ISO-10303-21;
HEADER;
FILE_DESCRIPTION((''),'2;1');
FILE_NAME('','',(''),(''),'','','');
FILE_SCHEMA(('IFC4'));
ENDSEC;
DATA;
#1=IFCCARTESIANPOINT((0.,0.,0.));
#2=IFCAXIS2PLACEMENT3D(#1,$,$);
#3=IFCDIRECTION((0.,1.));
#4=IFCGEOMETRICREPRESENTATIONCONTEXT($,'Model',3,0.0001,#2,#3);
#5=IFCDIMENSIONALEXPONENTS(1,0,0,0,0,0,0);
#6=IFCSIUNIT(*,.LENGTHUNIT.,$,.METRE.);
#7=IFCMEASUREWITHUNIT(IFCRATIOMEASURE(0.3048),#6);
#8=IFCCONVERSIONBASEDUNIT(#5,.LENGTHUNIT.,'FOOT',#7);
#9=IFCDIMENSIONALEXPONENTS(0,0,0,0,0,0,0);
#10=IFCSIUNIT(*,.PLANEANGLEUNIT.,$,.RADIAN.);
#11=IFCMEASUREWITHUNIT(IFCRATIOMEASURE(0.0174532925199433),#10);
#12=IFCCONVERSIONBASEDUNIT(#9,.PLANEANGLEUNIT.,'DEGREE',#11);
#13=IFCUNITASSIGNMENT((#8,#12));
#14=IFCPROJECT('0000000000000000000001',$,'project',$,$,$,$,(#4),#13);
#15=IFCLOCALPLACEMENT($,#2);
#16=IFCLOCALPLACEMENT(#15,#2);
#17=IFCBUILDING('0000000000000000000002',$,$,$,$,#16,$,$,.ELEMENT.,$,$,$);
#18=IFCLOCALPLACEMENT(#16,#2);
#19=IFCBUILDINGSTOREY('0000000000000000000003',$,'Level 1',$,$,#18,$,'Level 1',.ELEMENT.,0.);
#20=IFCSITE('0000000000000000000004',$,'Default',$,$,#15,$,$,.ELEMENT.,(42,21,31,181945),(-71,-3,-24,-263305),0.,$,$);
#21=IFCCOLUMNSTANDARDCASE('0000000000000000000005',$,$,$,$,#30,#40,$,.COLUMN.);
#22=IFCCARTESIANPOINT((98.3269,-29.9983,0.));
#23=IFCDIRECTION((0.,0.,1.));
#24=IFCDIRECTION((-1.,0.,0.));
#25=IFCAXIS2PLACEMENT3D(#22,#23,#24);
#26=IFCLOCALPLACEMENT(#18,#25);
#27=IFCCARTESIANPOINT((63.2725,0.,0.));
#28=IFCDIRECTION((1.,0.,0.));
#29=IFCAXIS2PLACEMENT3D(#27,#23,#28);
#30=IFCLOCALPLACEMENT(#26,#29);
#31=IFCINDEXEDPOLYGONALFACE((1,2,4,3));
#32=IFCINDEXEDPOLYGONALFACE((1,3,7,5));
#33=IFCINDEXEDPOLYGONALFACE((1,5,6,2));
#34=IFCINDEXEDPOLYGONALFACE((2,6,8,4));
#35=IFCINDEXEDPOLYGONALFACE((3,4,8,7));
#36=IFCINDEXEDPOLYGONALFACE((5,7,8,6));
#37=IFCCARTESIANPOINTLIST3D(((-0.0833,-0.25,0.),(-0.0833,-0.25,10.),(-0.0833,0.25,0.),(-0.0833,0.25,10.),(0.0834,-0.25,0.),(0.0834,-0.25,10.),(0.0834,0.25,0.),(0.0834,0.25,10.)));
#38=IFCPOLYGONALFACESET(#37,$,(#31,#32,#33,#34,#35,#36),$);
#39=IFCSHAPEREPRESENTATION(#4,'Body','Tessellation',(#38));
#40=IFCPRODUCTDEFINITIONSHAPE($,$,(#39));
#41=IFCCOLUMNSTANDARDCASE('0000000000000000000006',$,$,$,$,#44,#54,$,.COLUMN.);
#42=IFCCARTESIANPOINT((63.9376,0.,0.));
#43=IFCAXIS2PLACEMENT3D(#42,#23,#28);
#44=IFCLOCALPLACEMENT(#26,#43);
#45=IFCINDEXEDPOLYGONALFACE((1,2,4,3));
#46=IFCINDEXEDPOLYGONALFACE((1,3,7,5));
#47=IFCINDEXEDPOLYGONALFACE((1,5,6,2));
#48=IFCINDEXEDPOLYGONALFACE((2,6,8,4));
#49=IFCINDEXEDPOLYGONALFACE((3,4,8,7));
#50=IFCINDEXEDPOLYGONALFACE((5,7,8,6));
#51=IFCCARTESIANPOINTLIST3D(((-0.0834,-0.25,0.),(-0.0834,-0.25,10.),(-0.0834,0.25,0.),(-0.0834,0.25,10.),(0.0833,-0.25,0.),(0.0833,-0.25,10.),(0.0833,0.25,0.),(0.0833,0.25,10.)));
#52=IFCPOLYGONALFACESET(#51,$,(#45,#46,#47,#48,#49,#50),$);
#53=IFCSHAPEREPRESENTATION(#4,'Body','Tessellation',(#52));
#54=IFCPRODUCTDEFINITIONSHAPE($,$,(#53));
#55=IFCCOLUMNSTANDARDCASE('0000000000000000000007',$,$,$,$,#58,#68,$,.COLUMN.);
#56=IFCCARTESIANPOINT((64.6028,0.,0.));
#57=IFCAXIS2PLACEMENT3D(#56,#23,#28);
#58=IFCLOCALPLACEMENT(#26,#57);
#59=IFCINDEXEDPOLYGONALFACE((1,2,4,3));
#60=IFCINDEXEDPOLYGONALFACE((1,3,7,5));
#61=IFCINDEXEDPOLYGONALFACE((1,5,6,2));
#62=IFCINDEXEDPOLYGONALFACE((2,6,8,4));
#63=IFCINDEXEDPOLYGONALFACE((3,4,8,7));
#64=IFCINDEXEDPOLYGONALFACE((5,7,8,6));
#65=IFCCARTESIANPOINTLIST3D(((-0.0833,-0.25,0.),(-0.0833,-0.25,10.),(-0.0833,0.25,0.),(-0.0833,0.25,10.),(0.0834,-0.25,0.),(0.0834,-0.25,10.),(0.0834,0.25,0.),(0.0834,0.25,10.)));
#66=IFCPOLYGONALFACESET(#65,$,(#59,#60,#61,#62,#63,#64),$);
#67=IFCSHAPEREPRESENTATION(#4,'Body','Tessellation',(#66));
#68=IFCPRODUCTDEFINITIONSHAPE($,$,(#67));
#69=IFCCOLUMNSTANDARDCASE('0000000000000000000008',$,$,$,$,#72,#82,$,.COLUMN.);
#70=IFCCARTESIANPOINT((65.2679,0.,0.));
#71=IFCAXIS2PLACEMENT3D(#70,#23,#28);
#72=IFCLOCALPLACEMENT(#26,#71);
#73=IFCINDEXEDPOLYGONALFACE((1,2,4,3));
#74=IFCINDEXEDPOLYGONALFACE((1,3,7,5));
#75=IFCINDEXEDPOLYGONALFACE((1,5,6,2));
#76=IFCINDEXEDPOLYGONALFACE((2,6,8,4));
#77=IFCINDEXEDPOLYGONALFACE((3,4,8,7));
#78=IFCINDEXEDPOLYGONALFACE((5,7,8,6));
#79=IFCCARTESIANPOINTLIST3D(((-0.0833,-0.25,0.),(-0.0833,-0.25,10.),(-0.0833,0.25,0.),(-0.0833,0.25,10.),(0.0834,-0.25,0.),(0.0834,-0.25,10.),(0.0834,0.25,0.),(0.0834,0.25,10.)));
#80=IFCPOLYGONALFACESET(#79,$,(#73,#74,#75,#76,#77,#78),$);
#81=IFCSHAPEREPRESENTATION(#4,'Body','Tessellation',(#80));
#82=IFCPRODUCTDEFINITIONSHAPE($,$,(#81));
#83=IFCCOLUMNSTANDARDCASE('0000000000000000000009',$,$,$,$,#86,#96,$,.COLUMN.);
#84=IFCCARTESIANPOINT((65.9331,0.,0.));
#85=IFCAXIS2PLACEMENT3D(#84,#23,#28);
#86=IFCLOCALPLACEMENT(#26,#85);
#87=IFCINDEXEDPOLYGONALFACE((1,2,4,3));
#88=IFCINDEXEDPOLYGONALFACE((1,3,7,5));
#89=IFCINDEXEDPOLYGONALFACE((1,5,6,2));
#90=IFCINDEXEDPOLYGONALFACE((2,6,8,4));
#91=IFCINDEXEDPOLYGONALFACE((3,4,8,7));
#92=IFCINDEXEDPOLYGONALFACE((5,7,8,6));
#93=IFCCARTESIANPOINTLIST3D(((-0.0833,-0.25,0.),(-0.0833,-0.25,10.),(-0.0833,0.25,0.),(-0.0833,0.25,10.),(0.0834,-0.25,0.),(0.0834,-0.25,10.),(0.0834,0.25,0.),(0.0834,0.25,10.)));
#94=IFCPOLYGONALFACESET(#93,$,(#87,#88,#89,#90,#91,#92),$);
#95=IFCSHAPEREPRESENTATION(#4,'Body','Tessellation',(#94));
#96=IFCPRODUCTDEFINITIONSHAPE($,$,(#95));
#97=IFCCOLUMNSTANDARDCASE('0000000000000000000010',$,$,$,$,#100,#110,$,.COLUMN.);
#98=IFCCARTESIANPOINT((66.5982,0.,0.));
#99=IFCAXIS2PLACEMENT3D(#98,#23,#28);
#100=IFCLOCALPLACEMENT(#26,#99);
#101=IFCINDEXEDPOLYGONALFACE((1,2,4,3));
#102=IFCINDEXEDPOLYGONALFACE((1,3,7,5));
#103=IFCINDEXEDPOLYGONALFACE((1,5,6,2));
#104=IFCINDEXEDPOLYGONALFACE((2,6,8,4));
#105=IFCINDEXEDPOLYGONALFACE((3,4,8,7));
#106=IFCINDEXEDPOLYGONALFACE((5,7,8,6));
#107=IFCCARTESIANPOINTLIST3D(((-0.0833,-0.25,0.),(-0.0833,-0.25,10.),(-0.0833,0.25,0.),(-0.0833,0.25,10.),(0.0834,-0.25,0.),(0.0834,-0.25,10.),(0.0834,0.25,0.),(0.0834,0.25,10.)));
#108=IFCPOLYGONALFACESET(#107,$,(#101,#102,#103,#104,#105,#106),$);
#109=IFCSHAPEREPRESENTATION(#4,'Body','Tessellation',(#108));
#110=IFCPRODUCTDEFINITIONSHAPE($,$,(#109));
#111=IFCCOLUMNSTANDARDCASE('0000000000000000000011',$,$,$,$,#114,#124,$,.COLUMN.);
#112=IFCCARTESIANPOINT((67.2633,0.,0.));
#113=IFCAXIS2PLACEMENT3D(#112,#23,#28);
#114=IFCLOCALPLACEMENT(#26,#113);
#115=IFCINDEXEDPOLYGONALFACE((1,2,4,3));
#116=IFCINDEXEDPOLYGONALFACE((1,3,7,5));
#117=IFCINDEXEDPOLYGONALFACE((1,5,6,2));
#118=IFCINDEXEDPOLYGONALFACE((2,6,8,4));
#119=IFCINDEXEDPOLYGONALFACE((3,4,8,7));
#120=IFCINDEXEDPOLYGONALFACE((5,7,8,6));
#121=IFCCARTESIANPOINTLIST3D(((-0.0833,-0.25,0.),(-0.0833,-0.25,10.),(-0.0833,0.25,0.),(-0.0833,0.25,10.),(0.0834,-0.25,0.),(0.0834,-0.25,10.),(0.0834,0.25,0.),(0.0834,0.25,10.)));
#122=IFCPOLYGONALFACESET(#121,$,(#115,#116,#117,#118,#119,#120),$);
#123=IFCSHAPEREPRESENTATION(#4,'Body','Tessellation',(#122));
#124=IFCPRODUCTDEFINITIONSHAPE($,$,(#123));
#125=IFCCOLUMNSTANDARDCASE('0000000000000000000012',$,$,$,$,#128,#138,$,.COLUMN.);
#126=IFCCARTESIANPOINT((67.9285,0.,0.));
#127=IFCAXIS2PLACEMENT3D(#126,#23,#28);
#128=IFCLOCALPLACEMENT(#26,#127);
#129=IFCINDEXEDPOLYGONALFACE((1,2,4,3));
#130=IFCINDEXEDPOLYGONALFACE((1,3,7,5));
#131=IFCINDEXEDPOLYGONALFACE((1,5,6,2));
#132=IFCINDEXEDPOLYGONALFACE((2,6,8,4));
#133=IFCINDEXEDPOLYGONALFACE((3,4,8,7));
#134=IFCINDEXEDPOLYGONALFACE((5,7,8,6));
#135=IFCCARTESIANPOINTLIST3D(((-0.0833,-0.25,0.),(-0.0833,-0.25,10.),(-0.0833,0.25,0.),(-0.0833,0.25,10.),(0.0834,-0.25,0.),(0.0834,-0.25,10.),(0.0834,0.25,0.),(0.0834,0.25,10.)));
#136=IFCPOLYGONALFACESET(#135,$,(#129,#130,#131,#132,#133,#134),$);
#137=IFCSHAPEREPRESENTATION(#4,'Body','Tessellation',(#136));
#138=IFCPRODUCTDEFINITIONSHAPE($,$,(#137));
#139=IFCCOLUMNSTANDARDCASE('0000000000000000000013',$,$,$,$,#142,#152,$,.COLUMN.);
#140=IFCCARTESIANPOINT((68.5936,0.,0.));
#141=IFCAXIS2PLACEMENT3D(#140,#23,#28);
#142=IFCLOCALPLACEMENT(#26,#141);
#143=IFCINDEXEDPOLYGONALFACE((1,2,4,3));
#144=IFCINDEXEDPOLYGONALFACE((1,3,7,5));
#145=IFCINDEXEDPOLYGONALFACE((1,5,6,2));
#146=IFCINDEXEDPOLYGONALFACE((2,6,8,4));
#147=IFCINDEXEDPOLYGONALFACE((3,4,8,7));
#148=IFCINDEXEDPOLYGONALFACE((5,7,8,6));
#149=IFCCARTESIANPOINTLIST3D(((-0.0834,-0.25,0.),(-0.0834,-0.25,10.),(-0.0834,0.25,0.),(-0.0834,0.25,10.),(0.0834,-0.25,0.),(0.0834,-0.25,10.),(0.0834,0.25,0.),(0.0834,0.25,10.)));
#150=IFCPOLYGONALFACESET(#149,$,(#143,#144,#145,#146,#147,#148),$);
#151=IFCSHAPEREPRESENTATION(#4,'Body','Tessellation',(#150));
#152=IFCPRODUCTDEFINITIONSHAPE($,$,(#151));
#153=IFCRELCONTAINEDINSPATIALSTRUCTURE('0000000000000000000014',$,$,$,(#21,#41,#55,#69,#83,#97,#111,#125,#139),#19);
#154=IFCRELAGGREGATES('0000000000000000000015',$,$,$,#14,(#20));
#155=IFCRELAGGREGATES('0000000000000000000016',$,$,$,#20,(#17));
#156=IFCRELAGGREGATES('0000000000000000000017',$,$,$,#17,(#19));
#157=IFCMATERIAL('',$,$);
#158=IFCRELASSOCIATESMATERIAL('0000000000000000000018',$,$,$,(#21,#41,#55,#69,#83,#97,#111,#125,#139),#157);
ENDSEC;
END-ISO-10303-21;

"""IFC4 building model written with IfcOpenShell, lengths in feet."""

from ifc_helpers import new_model, entity, si_unit, converted_unit, direction, frame, origin, place, context, project, spatial, rectangle, extrude, material, element, save


model = new_model("IFC4")

# Units and contexts
model_context = context("Model", 3, precision=0.0001, world=origin(), true_north=direction((0.0, 1.0)))
ifc_project = project(units=[converted_unit("LENGTHUNIT", "FOOT", entity("IfcRatioMeasure", 0.3048), si_unit("LENGTHUNIT", "METRE"), dimensions=[1, 0, 0, 0, 0, 0, 0]), converted_unit("PLANEANGLEUNIT", "DEGREE", entity("IfcRatioMeasure", 0.0174532925199433), si_unit("PLANEANGLEUNIT", "RADIAN"), dimensions=[0, 0, 0, 0, 0, 0, 0])], contexts=[model_context])

# Site, building, storey
site_placement = place(None, origin())
site = spatial("IfcSite", under=ifc_project, at=site_placement, Name="Default", CompositionType="ELEMENT", RefLatitude=(42, 21, 31, 181945), RefLongitude=(-71, -3, -24, -263305), RefElevation=0.0)
building_placement = place(site_placement, origin())
building = spatial("IfcBuilding", under=site, at=building_placement, CompositionType="ELEMENT")
storey_placement = place(building_placement, origin())
storey = spatial("IfcBuildingStorey", under=building, at=storey_placement, Name="Level 1", LongName="Level 1", CompositionType="ELEMENT", Elevation=0.0)

# Columns
ifc_material_1 = material(Name="")
placement = place(storey_placement, frame((98.3269, -29.9983, 0.0), z_axis=(0.0, 0.0, 1.0), x_axis=(-1.0, 0.0, 0.0)))
for number, where, z_axis, x_axis in (
    (1, (63.2725, 0.0, 0.0), (0.0, 0.0, 1.0), (1.0, 0.0, 0.0)),
    (2, (63.9376, 0.0, 0.0), (0.0, 0.0, 1.0), (1.0, 0.0, 0.0)),
    (3, (64.6028, 0.0, 0.0), (0.0, 0.0, 1.0), (1.0, 0.0, 0.0)),
    (4, (65.2679, 0.0, 0.0), (0.0, 0.0, 1.0), (1.0, 0.0, 0.0)),
    (5, (65.9331, 0.0, 0.0), (0.0, 0.0, 1.0), (1.0, 0.0, 0.0)),
    (6, (66.5982, 0.0, 0.0), (0.0, 0.0, 1.0), (1.0, 0.0, 0.0)),
    (7, (67.2633, 0.0, 0.0), (0.0, 0.0, 1.0), (1.0, 0.0, 0.0)),
    (8, (67.9285, 0.0, 0.0), (0.0, 0.0, 1.0), (1.0, 0.0, 0.0)),
    (9, (68.5936, 0.0, 0.0), (0.0, 0.0, 1.0), (1.0, 0.0, 0.0)),
):
    element("IfcColumnStandardCase", number, at=place(placement, frame(where, z_axis=z_axis, x_axis=x_axis)), inside=storey, material=ifc_material_1, PredefinedType="COLUMN", context=model_context, shape_type="SweptSolid", body=[
        extrude(rectangle(XDim=0.1667, YDim=0.5), origin(), (0.0, 0.0, 1.0), 10.0),
    ])

save(model, "model.ifc")
